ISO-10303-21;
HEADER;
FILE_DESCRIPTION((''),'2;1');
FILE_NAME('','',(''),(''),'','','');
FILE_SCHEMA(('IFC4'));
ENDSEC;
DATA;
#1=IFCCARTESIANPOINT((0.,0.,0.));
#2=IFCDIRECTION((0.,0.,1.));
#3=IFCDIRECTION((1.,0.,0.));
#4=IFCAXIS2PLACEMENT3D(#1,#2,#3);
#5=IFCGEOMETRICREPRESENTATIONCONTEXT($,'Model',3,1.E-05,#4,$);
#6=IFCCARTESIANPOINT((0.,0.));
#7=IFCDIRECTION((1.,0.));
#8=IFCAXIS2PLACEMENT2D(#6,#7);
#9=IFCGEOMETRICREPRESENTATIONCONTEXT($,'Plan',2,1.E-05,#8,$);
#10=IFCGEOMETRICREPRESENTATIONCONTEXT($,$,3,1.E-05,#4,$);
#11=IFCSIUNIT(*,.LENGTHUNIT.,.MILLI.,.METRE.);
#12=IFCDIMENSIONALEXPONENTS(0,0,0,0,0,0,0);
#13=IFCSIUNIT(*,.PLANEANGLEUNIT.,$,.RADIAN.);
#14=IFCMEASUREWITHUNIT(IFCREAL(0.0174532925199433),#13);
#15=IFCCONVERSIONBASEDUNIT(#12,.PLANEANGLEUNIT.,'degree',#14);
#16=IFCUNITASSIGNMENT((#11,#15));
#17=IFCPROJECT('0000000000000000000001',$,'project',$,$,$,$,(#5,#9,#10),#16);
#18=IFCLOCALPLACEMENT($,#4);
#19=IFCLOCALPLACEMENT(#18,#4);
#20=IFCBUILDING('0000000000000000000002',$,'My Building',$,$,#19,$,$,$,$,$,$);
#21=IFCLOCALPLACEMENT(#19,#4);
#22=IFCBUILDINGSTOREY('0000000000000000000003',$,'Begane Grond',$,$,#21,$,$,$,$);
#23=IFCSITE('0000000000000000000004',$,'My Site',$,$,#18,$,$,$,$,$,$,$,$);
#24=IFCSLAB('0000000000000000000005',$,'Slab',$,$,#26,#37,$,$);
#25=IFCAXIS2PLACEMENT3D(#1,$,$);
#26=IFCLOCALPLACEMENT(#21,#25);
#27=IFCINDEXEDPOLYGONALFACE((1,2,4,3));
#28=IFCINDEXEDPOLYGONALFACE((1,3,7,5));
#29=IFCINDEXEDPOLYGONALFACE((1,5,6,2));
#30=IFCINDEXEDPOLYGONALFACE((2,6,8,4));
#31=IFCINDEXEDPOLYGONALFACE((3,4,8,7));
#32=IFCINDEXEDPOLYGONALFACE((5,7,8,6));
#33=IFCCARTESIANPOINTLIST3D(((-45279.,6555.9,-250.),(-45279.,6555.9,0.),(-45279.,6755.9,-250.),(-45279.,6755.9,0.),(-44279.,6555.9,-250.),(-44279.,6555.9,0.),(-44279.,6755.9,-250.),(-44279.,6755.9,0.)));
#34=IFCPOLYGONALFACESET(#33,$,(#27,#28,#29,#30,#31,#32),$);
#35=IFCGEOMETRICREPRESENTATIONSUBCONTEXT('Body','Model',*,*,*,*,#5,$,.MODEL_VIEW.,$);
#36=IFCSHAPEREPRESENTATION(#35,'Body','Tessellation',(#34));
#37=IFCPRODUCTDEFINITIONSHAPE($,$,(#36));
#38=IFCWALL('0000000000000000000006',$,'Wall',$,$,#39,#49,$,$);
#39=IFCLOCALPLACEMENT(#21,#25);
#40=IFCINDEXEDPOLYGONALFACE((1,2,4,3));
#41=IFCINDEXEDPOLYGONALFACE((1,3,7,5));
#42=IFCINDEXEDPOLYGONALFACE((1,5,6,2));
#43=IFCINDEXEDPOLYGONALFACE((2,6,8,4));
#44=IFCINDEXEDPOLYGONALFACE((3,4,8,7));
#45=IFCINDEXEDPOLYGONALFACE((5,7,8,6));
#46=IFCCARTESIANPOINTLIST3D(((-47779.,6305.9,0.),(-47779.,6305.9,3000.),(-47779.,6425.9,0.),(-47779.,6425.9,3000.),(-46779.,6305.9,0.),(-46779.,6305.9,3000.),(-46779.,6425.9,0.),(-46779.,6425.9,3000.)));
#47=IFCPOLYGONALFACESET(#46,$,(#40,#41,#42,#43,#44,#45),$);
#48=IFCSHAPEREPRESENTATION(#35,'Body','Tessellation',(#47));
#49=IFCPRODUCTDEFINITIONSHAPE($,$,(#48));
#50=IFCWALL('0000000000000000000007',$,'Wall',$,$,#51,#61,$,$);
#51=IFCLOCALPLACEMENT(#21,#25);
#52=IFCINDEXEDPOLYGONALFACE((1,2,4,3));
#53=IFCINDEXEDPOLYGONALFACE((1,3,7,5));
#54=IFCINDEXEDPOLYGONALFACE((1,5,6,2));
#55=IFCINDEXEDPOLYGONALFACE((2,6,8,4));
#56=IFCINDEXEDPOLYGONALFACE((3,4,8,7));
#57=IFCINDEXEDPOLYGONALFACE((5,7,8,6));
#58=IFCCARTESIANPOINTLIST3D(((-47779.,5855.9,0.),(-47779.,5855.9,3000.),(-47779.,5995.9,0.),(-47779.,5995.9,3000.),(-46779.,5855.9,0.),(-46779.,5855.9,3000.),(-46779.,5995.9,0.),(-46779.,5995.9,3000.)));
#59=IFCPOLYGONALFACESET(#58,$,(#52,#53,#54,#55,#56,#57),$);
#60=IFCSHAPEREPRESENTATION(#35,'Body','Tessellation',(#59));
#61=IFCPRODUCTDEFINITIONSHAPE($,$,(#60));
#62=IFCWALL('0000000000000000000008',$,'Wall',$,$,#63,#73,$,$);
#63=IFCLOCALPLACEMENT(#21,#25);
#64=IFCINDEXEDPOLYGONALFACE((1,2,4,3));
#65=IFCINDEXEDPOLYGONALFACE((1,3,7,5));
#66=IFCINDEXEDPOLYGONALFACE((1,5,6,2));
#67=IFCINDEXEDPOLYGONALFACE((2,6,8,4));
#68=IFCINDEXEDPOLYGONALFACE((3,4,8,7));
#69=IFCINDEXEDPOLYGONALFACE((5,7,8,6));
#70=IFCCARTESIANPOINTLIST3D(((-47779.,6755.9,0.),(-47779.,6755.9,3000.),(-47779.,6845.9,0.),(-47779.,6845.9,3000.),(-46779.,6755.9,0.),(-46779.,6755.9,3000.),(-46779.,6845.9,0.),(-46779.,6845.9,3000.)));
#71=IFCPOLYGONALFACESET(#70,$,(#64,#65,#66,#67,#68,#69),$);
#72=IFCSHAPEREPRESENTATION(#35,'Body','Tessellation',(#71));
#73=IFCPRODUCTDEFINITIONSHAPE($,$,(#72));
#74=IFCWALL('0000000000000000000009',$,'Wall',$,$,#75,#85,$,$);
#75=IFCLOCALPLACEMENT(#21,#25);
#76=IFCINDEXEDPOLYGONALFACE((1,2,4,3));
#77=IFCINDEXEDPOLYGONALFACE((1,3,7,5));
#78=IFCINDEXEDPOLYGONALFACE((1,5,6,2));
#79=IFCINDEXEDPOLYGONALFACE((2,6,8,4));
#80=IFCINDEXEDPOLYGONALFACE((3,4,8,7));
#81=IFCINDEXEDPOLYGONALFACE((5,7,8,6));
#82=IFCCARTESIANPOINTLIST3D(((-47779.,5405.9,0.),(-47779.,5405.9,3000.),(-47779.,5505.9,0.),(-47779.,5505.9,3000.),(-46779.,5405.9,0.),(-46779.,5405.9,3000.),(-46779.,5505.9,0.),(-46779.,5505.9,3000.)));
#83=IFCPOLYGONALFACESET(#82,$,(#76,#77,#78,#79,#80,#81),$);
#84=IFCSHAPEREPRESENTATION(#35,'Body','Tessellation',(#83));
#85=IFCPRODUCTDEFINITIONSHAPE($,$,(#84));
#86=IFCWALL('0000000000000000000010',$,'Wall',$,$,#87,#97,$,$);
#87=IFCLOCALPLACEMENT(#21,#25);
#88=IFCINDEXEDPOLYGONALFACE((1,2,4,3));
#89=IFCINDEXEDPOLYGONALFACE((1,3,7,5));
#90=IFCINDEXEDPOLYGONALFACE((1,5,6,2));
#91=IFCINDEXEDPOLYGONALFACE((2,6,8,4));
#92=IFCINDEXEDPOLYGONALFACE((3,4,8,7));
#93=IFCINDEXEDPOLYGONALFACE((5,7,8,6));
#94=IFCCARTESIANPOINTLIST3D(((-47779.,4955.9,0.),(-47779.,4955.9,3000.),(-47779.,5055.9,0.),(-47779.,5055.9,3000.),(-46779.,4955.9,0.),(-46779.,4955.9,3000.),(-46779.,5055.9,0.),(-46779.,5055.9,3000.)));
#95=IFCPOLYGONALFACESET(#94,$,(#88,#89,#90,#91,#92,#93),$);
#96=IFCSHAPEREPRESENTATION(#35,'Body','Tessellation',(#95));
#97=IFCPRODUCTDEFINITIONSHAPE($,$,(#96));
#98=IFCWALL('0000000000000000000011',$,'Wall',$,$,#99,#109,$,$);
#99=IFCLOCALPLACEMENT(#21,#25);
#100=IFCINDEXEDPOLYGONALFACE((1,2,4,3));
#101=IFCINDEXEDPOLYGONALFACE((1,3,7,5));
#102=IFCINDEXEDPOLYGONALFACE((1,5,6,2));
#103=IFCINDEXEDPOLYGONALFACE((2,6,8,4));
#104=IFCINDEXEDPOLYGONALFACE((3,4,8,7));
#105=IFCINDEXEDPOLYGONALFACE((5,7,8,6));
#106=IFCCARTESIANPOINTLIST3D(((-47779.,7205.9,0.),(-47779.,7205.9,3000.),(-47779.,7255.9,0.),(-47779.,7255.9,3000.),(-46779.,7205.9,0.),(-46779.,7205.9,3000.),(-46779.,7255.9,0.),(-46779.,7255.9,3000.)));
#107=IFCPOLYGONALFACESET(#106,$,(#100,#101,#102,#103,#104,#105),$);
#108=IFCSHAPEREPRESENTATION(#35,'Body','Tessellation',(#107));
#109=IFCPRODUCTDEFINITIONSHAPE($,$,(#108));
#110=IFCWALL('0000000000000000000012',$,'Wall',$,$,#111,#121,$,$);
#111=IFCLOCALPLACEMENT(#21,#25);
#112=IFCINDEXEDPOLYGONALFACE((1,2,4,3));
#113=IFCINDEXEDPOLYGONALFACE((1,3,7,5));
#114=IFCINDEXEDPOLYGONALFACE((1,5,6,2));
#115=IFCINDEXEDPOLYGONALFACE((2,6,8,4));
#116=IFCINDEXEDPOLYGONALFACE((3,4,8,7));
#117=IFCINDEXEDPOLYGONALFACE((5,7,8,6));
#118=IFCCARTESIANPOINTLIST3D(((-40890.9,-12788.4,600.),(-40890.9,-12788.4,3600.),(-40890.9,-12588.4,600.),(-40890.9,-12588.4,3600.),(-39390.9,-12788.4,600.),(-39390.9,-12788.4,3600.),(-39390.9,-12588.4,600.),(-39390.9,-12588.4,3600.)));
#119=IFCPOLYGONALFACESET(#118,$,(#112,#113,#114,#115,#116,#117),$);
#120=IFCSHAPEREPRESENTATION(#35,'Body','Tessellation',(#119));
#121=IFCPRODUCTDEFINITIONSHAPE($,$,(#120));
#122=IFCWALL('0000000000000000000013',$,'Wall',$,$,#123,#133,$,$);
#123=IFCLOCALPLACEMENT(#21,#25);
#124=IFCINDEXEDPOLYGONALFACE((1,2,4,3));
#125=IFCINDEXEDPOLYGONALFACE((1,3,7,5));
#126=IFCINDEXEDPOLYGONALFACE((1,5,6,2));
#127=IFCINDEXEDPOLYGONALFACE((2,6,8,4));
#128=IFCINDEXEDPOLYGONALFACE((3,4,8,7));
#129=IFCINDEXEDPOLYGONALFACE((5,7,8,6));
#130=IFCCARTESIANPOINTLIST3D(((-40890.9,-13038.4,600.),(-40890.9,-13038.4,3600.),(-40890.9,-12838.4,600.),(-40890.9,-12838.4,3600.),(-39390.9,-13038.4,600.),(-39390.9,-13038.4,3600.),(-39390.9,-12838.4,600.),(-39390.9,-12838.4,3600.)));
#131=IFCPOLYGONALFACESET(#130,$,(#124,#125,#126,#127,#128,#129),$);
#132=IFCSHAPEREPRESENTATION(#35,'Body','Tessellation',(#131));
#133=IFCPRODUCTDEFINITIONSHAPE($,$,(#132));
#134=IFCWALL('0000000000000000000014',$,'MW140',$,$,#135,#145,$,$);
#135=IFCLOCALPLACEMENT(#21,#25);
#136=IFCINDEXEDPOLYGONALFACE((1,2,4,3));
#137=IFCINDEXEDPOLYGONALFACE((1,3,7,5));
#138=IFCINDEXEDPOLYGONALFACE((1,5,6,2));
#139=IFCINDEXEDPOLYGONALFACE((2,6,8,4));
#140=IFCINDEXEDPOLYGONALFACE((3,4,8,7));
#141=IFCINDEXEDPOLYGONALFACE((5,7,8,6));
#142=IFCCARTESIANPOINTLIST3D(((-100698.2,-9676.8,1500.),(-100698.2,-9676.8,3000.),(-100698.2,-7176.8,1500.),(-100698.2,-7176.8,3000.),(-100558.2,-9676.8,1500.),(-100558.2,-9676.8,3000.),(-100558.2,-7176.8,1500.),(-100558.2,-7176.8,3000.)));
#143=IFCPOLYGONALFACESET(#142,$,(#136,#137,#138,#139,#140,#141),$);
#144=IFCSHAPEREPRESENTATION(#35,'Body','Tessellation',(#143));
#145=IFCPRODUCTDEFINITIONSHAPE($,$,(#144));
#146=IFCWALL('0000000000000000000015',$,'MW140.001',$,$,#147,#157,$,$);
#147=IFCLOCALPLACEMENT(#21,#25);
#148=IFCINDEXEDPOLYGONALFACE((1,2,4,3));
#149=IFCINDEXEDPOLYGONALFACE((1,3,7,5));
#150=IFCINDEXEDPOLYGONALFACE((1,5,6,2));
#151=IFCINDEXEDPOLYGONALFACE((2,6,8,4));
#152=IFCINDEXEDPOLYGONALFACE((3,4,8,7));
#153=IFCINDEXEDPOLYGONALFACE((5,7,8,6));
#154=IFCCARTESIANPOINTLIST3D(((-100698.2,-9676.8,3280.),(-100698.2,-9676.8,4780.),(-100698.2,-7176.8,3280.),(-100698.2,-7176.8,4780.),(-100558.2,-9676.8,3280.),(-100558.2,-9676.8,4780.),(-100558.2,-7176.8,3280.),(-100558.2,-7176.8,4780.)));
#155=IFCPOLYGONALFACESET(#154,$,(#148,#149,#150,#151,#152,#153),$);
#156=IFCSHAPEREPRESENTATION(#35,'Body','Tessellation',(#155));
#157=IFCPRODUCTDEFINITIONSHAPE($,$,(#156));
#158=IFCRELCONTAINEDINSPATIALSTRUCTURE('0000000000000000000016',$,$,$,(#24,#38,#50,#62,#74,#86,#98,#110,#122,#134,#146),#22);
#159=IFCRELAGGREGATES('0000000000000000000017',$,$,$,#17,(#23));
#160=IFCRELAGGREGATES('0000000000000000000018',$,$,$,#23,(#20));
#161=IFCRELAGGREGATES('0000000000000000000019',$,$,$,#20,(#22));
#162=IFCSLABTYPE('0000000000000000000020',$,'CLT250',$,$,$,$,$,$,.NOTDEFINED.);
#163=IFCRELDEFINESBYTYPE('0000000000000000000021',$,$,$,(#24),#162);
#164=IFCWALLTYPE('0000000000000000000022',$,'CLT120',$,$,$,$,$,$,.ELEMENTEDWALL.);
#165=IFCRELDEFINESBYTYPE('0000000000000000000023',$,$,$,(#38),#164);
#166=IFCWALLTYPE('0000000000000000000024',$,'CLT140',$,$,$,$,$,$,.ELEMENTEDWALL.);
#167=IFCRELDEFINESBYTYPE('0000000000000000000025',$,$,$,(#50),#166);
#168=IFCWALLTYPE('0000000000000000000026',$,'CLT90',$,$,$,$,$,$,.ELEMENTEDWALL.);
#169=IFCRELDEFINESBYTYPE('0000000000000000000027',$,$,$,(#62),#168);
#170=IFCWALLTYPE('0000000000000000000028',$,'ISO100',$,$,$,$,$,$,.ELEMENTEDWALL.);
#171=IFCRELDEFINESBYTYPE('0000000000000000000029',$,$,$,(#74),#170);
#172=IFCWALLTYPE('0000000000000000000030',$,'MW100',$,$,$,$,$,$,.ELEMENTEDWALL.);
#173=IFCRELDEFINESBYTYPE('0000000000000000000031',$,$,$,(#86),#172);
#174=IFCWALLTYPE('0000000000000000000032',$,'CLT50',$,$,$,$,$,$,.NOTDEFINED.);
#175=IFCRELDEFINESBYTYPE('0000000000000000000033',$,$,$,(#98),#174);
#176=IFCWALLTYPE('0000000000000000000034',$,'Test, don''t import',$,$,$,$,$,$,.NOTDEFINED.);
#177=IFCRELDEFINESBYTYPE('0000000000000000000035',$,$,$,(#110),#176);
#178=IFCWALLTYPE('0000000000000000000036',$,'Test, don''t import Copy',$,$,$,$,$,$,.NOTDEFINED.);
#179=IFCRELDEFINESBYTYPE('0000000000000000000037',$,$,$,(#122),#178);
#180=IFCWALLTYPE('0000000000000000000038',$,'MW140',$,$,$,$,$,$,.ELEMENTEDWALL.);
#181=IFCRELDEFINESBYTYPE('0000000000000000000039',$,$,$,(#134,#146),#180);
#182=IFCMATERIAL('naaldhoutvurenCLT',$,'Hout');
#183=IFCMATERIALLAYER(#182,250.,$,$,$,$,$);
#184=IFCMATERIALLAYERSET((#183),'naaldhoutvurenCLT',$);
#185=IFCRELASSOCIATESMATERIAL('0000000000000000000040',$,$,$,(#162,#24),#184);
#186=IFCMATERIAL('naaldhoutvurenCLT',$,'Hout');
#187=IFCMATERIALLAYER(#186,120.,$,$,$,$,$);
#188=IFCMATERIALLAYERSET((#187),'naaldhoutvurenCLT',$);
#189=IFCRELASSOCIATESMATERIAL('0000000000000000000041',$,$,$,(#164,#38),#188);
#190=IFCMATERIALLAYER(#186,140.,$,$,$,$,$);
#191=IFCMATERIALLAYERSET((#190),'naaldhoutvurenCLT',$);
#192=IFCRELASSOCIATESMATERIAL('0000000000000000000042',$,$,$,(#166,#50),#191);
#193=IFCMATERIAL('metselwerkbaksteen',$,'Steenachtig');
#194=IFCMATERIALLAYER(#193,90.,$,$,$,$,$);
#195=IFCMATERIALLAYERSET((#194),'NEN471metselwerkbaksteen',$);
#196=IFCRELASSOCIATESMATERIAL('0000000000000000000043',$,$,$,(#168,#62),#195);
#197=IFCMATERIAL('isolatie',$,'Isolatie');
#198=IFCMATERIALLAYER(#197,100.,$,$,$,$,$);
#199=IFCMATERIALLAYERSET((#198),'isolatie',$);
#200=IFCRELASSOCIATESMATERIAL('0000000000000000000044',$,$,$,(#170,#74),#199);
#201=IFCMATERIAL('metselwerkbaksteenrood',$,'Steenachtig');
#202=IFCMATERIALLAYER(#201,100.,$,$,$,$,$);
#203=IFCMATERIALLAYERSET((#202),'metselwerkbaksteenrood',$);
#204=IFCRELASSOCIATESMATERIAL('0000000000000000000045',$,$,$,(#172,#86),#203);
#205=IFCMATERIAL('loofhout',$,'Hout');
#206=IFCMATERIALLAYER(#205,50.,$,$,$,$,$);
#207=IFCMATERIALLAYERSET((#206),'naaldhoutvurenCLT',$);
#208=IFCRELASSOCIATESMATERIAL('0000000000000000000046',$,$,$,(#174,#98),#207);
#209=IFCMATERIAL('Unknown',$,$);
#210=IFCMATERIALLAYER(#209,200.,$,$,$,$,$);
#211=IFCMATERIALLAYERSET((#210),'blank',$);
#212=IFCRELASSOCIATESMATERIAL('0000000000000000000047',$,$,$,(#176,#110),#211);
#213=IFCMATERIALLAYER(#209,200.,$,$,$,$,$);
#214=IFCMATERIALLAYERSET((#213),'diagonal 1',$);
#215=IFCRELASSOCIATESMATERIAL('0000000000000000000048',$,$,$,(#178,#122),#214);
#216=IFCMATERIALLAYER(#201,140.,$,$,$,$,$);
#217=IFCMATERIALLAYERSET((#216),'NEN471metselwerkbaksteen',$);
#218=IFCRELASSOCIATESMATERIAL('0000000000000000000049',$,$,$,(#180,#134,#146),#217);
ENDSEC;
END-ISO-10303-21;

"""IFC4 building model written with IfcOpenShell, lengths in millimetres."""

from ifc_helpers import new_model, entity, si_unit, converted_unit, frame, origin_with_axes, origin_2d_with_axis, place, context, subcontext, project, spatial, line, indexed_curve, outline, extrude, material, layer, layer_set, layer_usage, type_object, element, save


model = new_model("IFC4")

# Units and contexts
model_context = context("Model", 3, precision=1e-05, world=origin_with_axes())
plan_context = context("Plan", 2, precision=1e-05, world=origin_2d_with_axis())
context_of_model = context(None, 3, precision=1e-05, world=origin_with_axes())
body_context = subcontext(model_context, "Body", "Model", "MODEL_VIEW")
ifc_project = project(units=[si_unit("LENGTHUNIT", "METRE", prefix="MILLI"), converted_unit("PLANEANGLEUNIT", "degree", entity("IfcReal", 0.0174532925199433), si_unit("PLANEANGLEUNIT", "RADIAN"), dimensions=[0, 0, 0, 0, 0, 0, 0])], contexts=[model_context, plan_context, context_of_model])

# Site, building, storey
site_placement = place(None, frame((0.0, 0.0, 0.0), z_axis=(0.0, 0.0, 1.0), x_axis=(1.0, 0.0, 0.0)))
site = spatial("IfcSite", under=ifc_project, at=site_placement, Name="My Site")
building_placement = place(site_placement, origin_with_axes())
building = spatial("IfcBuilding", under=site, at=building_placement, Name="My Building")
storey_placement = place(building_placement, origin_with_axes())
storey = spatial("IfcBuildingStorey", under=building, at=storey_placement, Name="Begane Grond")

# Slab
ifc_material_1 = material(Name="naaldhoutvurenCLT", Category="Hout")
ifc_material_2 = material(Name="isolatie", Category="Isolatie")
ifc_material_3 = material(Name="naaldhoutvurenCLT", Category="Hout")
ifc_layer_1 = layer(ifc_material_3, 250.0)
ifc_layer_set_1 = layer_set([ifc_layer_1], Name="naaldhoutvurenCLT")
ifc_layer_usage_1 = layer_usage(ifc_layer_set_1, "AXIS3", "POSITIVE", 0.0)
slab_type_1 = type_object("IfcSlabType", Name="CLT250", PredefinedType="NOTDEFINED", material=ifc_layer_set_1)
slab_1_placement = place(storey_placement, frame((-45279.0, 6555.9, -250.0), z_axis=(0.0, 0.0, 1.0), x_axis=(1.0, 0.0, 0.0)))
element("IfcSlab", 1, at=slab_1_placement, inside=storey, type_object=slab_type_1, material=ifc_layer_usage_1, Name="Slab", context=body_context, shape_type="SweptSolid", body=[
    extrude(outline(indexed_curve([(1000.0, 200.0), (1000.0, 0.0), (0.0, 0.0), (0.0, 200.0)], segments=[line(3, 2), line(2, 1), line(1, 4), line(4, 3)], self_intersect=False)), None, (0.0, 0.0, 1.0), 250.0),
])

# Walls
ifc_layer_2 = layer(ifc_material_1, 120.0)
ifc_layer_set_2 = layer_set([ifc_layer_2], Name="naaldhoutvurenCLT")
ifc_layer_usage_2 = layer_usage(ifc_layer_set_2, "AXIS2", "POSITIVE", 0.0)
wall_type_1 = type_object("IfcWallType", Name="CLT120", PredefinedType="ELEMENTEDWALL", material=ifc_layer_set_2)
wall_1_placement = place(storey_placement, frame((-47779.0, 6305.9, 0.0), z_axis=(0.0, 0.0, 1.0), x_axis=(1.0, 0.0, 0.0)))
element("IfcWall", 2, at=wall_1_placement, inside=storey, type_object=wall_type_1, material=ifc_layer_usage_2, Name="Wall", context=body_context, shape_type="SweptSolid", body=[
    extrude(outline(indexed_curve([(0.0, 0.0), (0.0, 120.0), (1000.0, 120.0), (1000.0, 0.0), (0.0, 0.0)], self_intersect=False)), origin_with_axes(), (0.0, 0.0, 1.0), 3000.0),
])
ifc_layer_3 = layer(ifc_material_1, 140.0)
ifc_layer_set_3 = layer_set([ifc_layer_3], Name="naaldhoutvurenCLT")
ifc_layer_usage_3 = layer_usage(ifc_layer_set_3, "AXIS2", "POSITIVE", 0.0)
wall_type_2 = type_object("IfcWallType", Name="CLT140", PredefinedType="ELEMENTEDWALL", material=ifc_layer_set_3)
wall_2_placement = place(storey_placement, frame((-47779.0, 5855.9, 0.0), z_axis=(0.0, 0.0, 1.0), x_axis=(1.0, 0.0, 0.0)))
element("IfcWall", 3, at=wall_2_placement, inside=storey, type_object=wall_type_2, material=ifc_layer_usage_3, Name="Wall", context=body_context, shape_type="SweptSolid", body=[
    extrude(outline(indexed_curve([(0.0, 0.0), (0.0, 140.0), (1000.0, 140.0), (1000.0, 0.0), (0.0, 0.0)], self_intersect=False)), origin_with_axes(), (0.0, 0.0, 1.0), 3000.0),
])
ifc_material_4 = material(Name="metselwerkbaksteen", Category="Steenachtig")
ifc_layer_4 = layer(ifc_material_4, 90.0)
ifc_layer_set_4 = layer_set([ifc_layer_4], Name="NEN471metselwerkbaksteen")
ifc_layer_usage_4 = layer_usage(ifc_layer_set_4, "AXIS2", "POSITIVE", 0.0)
wall_type_3 = type_object("IfcWallType", Name="CLT90", PredefinedType="ELEMENTEDWALL", material=ifc_layer_set_4)
wall_3_placement = place(storey_placement, frame((-47779.0, 6755.9, 0.0), z_axis=(0.0, 0.0, 1.0), x_axis=(1.0, 0.0, 0.0)))
element("IfcWall", 4, at=wall_3_placement, inside=storey, type_object=wall_type_3, material=ifc_layer_usage_4, Name="Wall", context=body_context, shape_type="SweptSolid", body=[
    extrude(outline(indexed_curve([(0.0, 0.0), (0.0, 90.0), (1000.0, 90.0), (1000.0, 0.0), (0.0, 0.0)], self_intersect=False)), origin_with_axes(), (0.0, 0.0, 1.0), 3000.0),
])
ifc_layer_5 = layer(ifc_material_2, 100.0)
ifc_layer_set_5 = layer_set([ifc_layer_5], Name="isolatie")
ifc_layer_usage_5 = layer_usage(ifc_layer_set_5, "AXIS2", "POSITIVE", 0.0)
wall_type_4 = type_object("IfcWallType", Name="ISO100", PredefinedType="ELEMENTEDWALL", material=ifc_layer_set_5)
wall_4_placement = place(storey_placement, frame((-47779.0, 5405.9, 0.0), z_axis=(0.0, 0.0, 1.0), x_axis=(1.0, 0.0, 0.0)))
element("IfcWall", 5, at=wall_4_placement, inside=storey, type_object=wall_type_4, material=ifc_layer_usage_5, Name="Wall", context=body_context, shape_type="SweptSolid", body=[
    extrude(outline(indexed_curve([(0.0, 0.0), (0.0, 100.0), (1000.0, 100.0), (1000.0, 0.0), (0.0, 0.0)], self_intersect=False)), origin_with_axes(), (0.0, 0.0, 1.0), 3000.0),
])
ifc_material_5 = material(Name="metselwerkbaksteenrood", Category="Steenachtig")
ifc_layer_6 = layer(ifc_material_5, 100.0)
ifc_layer_set_6 = layer_set([ifc_layer_6], Name="metselwerkbaksteenrood")
ifc_layer_usage_6 = layer_usage(ifc_layer_set_6, "AXIS2", "POSITIVE", 0.0)
wall_type_5 = type_object("IfcWallType", Name="MW100", PredefinedType="ELEMENTEDWALL", material=ifc_layer_set_6)
wall_5_placement = place(storey_placement, frame((-47779.0, 4955.9, 0.0), z_axis=(0.0, 0.0, 1.0), x_axis=(1.0, 0.0, 0.0)))
element("IfcWall", 6, at=wall_5_placement, inside=storey, type_object=wall_type_5, material=ifc_layer_usage_6, Name="Wall", context=body_context, shape_type="SweptSolid", body=[
    extrude(outline(indexed_curve([(0.0, 0.0), (0.0, 100.0), (1000.0, 100.0), (1000.0, 0.0), (0.0, 0.0)], self_intersect=False)), origin_with_axes(), (0.0, 0.0, 1.0), 3000.0),
])
ifc_material_6 = material(Name="loofhout", Category="Hout")
ifc_layer_7 = layer(ifc_material_6, 50.0)
ifc_layer_set_7 = layer_set([ifc_layer_7], Name="naaldhoutvurenCLT")
ifc_layer_usage_7 = layer_usage(ifc_layer_set_7, "AXIS2", "POSITIVE", 0.0)
wall_type_6 = type_object("IfcWallType", Name="CLT50", PredefinedType="NOTDEFINED", material=ifc_layer_set_7)
wall_6_placement = place(storey_placement, frame((-47779.0, 7205.9, 0.0), z_axis=(0.0, 0.0, 1.0), x_axis=(1.0, 0.0, 0.0)))
element("IfcWall", 7, at=wall_6_placement, inside=storey, type_object=wall_type_6, material=ifc_layer_usage_7, Name="Wall", context=body_context, shape_type="SweptSolid", body=[
    extrude(outline(indexed_curve([(0.0, 0.0), (0.0, 50.0), (1000.0, 50.0), (1000.0, 0.0), (0.0, 0.0)], self_intersect=False)), origin_with_axes(), (0.0, 0.0, 1.0), 3000.0),
])
ifc_material_7 = material(Name="Unknown")
ifc_layer_8 = layer(ifc_material_7, 200.0)
ifc_layer_set_8 = layer_set([ifc_layer_8], Name="blank")
ifc_layer_usage_8 = layer_usage(ifc_layer_set_8, "AXIS2", "POSITIVE", 0.0)
wall_type_7 = type_object("IfcWallType", Name="Test, don't import", PredefinedType="NOTDEFINED", material=ifc_layer_set_8)
wall_7_placement = place(storey_placement, frame((-40890.9, -12788.4, 600.0), z_axis=(0.0, 0.0, 1.0), x_axis=(1.0, 0.0, 0.0)))
element("IfcWall", 8, at=wall_7_placement, inside=storey, type_object=wall_type_7, material=ifc_layer_usage_8, Name="Wall", context=body_context, shape_type="SweptSolid", body=[
    extrude(outline(indexed_curve([(0.0, 0.0), (0.0, 200.0), (1500.0, 200.0), (1500.0, 0.0), (0.0, 0.0)], self_intersect=False)), origin_with_axes(), (0.0, 0.0, 1.0), 3000.0),
])
ifc_layer_9 = layer(ifc_material_7, 200.0)
ifc_layer_set_9 = layer_set([ifc_layer_9], Name="diagonal 1")
ifc_layer_usage_9 = layer_usage(ifc_layer_set_9, "AXIS2", "POSITIVE", 0.0)
wall_type_8 = type_object("IfcWallType", Name="Test, don't import Copy", PredefinedType="NOTDEFINED", material=ifc_layer_set_9)
wall_8_placement = place(storey_placement, frame((-40890.9, -13038.4, 600.0), z_axis=(0.0, 0.0, 1.0), x_axis=(1.0, 0.0, 0.0)))
element("IfcWall", 9, at=wall_8_placement, inside=storey, type_object=wall_type_8, material=ifc_layer_usage_9, Name="Wall", context=body_context, shape_type="SweptSolid", body=[
    extrude(outline(indexed_curve([(0.0, 0.0), (0.0, 200.0), (1500.0, 200.0), (1500.0, 0.0), (0.0, 0.0)], self_intersect=False)), origin_with_axes(), (0.0, 0.0, 1.0), 3000.0),
])
ifc_layer_10 = layer(ifc_material_5, 140.0)
ifc_layer_set_10 = layer_set([ifc_layer_10], Name="NEN471metselwerkbaksteen")
ifc_layer_usage_10 = layer_usage(ifc_layer_set_10, "AXIS2", "POSITIVE", 0.0)
wall_type_9 = type_object("IfcWallType", Name="MW140", PredefinedType="ELEMENTEDWALL", material=ifc_layer_set_10)
wall_9_placement = place(storey_placement, frame((-100558.2, -9676.8, 1500.0), z_axis=(0.0, 0.0, 1.0), x_axis=(0.0, 1.0, 0.0)))
element("IfcWall", 10, at=wall_9_placement, inside=storey, type_object=wall_type_9, material=ifc_layer_usage_10, Name="MW140", context=body_context, shape_type="SweptSolid", body=[
    extrude(outline(indexed_curve([(0.0, 0.0), (0.0, 140.0), (2500.0, 140.0), (2500.0, 0.0), (0.0, 0.0)], self_intersect=False)), origin_with_axes(), (0.0, 0.0, 1.0), 1500.0),
])
ifc_layer_usage_11 = layer_usage(ifc_layer_set_10, "AXIS2", "POSITIVE", 0.0)
wall_10_placement = place(storey_placement, frame((-100558.2, -9676.8, 3280.0), z_axis=(0.0, 0.0, 1.0), x_axis=(0.0, 1.0, 0.0)))
element("IfcWall", 11, at=wall_10_placement, inside=storey, type_object=wall_type_9, material=ifc_layer_usage_11, Name="MW140.001", context=body_context, shape_type="SweptSolid", body=[
    extrude(outline(indexed_curve([(0.0, 0.0), (0.0, 140.0), (2500.0, 140.0), (2500.0, 0.0), (0.0, 0.0)], self_intersect=False)), origin_with_axes(), (0.0, 0.0, 1.0), 1500.0),
])

save(model, "model.ifc")
